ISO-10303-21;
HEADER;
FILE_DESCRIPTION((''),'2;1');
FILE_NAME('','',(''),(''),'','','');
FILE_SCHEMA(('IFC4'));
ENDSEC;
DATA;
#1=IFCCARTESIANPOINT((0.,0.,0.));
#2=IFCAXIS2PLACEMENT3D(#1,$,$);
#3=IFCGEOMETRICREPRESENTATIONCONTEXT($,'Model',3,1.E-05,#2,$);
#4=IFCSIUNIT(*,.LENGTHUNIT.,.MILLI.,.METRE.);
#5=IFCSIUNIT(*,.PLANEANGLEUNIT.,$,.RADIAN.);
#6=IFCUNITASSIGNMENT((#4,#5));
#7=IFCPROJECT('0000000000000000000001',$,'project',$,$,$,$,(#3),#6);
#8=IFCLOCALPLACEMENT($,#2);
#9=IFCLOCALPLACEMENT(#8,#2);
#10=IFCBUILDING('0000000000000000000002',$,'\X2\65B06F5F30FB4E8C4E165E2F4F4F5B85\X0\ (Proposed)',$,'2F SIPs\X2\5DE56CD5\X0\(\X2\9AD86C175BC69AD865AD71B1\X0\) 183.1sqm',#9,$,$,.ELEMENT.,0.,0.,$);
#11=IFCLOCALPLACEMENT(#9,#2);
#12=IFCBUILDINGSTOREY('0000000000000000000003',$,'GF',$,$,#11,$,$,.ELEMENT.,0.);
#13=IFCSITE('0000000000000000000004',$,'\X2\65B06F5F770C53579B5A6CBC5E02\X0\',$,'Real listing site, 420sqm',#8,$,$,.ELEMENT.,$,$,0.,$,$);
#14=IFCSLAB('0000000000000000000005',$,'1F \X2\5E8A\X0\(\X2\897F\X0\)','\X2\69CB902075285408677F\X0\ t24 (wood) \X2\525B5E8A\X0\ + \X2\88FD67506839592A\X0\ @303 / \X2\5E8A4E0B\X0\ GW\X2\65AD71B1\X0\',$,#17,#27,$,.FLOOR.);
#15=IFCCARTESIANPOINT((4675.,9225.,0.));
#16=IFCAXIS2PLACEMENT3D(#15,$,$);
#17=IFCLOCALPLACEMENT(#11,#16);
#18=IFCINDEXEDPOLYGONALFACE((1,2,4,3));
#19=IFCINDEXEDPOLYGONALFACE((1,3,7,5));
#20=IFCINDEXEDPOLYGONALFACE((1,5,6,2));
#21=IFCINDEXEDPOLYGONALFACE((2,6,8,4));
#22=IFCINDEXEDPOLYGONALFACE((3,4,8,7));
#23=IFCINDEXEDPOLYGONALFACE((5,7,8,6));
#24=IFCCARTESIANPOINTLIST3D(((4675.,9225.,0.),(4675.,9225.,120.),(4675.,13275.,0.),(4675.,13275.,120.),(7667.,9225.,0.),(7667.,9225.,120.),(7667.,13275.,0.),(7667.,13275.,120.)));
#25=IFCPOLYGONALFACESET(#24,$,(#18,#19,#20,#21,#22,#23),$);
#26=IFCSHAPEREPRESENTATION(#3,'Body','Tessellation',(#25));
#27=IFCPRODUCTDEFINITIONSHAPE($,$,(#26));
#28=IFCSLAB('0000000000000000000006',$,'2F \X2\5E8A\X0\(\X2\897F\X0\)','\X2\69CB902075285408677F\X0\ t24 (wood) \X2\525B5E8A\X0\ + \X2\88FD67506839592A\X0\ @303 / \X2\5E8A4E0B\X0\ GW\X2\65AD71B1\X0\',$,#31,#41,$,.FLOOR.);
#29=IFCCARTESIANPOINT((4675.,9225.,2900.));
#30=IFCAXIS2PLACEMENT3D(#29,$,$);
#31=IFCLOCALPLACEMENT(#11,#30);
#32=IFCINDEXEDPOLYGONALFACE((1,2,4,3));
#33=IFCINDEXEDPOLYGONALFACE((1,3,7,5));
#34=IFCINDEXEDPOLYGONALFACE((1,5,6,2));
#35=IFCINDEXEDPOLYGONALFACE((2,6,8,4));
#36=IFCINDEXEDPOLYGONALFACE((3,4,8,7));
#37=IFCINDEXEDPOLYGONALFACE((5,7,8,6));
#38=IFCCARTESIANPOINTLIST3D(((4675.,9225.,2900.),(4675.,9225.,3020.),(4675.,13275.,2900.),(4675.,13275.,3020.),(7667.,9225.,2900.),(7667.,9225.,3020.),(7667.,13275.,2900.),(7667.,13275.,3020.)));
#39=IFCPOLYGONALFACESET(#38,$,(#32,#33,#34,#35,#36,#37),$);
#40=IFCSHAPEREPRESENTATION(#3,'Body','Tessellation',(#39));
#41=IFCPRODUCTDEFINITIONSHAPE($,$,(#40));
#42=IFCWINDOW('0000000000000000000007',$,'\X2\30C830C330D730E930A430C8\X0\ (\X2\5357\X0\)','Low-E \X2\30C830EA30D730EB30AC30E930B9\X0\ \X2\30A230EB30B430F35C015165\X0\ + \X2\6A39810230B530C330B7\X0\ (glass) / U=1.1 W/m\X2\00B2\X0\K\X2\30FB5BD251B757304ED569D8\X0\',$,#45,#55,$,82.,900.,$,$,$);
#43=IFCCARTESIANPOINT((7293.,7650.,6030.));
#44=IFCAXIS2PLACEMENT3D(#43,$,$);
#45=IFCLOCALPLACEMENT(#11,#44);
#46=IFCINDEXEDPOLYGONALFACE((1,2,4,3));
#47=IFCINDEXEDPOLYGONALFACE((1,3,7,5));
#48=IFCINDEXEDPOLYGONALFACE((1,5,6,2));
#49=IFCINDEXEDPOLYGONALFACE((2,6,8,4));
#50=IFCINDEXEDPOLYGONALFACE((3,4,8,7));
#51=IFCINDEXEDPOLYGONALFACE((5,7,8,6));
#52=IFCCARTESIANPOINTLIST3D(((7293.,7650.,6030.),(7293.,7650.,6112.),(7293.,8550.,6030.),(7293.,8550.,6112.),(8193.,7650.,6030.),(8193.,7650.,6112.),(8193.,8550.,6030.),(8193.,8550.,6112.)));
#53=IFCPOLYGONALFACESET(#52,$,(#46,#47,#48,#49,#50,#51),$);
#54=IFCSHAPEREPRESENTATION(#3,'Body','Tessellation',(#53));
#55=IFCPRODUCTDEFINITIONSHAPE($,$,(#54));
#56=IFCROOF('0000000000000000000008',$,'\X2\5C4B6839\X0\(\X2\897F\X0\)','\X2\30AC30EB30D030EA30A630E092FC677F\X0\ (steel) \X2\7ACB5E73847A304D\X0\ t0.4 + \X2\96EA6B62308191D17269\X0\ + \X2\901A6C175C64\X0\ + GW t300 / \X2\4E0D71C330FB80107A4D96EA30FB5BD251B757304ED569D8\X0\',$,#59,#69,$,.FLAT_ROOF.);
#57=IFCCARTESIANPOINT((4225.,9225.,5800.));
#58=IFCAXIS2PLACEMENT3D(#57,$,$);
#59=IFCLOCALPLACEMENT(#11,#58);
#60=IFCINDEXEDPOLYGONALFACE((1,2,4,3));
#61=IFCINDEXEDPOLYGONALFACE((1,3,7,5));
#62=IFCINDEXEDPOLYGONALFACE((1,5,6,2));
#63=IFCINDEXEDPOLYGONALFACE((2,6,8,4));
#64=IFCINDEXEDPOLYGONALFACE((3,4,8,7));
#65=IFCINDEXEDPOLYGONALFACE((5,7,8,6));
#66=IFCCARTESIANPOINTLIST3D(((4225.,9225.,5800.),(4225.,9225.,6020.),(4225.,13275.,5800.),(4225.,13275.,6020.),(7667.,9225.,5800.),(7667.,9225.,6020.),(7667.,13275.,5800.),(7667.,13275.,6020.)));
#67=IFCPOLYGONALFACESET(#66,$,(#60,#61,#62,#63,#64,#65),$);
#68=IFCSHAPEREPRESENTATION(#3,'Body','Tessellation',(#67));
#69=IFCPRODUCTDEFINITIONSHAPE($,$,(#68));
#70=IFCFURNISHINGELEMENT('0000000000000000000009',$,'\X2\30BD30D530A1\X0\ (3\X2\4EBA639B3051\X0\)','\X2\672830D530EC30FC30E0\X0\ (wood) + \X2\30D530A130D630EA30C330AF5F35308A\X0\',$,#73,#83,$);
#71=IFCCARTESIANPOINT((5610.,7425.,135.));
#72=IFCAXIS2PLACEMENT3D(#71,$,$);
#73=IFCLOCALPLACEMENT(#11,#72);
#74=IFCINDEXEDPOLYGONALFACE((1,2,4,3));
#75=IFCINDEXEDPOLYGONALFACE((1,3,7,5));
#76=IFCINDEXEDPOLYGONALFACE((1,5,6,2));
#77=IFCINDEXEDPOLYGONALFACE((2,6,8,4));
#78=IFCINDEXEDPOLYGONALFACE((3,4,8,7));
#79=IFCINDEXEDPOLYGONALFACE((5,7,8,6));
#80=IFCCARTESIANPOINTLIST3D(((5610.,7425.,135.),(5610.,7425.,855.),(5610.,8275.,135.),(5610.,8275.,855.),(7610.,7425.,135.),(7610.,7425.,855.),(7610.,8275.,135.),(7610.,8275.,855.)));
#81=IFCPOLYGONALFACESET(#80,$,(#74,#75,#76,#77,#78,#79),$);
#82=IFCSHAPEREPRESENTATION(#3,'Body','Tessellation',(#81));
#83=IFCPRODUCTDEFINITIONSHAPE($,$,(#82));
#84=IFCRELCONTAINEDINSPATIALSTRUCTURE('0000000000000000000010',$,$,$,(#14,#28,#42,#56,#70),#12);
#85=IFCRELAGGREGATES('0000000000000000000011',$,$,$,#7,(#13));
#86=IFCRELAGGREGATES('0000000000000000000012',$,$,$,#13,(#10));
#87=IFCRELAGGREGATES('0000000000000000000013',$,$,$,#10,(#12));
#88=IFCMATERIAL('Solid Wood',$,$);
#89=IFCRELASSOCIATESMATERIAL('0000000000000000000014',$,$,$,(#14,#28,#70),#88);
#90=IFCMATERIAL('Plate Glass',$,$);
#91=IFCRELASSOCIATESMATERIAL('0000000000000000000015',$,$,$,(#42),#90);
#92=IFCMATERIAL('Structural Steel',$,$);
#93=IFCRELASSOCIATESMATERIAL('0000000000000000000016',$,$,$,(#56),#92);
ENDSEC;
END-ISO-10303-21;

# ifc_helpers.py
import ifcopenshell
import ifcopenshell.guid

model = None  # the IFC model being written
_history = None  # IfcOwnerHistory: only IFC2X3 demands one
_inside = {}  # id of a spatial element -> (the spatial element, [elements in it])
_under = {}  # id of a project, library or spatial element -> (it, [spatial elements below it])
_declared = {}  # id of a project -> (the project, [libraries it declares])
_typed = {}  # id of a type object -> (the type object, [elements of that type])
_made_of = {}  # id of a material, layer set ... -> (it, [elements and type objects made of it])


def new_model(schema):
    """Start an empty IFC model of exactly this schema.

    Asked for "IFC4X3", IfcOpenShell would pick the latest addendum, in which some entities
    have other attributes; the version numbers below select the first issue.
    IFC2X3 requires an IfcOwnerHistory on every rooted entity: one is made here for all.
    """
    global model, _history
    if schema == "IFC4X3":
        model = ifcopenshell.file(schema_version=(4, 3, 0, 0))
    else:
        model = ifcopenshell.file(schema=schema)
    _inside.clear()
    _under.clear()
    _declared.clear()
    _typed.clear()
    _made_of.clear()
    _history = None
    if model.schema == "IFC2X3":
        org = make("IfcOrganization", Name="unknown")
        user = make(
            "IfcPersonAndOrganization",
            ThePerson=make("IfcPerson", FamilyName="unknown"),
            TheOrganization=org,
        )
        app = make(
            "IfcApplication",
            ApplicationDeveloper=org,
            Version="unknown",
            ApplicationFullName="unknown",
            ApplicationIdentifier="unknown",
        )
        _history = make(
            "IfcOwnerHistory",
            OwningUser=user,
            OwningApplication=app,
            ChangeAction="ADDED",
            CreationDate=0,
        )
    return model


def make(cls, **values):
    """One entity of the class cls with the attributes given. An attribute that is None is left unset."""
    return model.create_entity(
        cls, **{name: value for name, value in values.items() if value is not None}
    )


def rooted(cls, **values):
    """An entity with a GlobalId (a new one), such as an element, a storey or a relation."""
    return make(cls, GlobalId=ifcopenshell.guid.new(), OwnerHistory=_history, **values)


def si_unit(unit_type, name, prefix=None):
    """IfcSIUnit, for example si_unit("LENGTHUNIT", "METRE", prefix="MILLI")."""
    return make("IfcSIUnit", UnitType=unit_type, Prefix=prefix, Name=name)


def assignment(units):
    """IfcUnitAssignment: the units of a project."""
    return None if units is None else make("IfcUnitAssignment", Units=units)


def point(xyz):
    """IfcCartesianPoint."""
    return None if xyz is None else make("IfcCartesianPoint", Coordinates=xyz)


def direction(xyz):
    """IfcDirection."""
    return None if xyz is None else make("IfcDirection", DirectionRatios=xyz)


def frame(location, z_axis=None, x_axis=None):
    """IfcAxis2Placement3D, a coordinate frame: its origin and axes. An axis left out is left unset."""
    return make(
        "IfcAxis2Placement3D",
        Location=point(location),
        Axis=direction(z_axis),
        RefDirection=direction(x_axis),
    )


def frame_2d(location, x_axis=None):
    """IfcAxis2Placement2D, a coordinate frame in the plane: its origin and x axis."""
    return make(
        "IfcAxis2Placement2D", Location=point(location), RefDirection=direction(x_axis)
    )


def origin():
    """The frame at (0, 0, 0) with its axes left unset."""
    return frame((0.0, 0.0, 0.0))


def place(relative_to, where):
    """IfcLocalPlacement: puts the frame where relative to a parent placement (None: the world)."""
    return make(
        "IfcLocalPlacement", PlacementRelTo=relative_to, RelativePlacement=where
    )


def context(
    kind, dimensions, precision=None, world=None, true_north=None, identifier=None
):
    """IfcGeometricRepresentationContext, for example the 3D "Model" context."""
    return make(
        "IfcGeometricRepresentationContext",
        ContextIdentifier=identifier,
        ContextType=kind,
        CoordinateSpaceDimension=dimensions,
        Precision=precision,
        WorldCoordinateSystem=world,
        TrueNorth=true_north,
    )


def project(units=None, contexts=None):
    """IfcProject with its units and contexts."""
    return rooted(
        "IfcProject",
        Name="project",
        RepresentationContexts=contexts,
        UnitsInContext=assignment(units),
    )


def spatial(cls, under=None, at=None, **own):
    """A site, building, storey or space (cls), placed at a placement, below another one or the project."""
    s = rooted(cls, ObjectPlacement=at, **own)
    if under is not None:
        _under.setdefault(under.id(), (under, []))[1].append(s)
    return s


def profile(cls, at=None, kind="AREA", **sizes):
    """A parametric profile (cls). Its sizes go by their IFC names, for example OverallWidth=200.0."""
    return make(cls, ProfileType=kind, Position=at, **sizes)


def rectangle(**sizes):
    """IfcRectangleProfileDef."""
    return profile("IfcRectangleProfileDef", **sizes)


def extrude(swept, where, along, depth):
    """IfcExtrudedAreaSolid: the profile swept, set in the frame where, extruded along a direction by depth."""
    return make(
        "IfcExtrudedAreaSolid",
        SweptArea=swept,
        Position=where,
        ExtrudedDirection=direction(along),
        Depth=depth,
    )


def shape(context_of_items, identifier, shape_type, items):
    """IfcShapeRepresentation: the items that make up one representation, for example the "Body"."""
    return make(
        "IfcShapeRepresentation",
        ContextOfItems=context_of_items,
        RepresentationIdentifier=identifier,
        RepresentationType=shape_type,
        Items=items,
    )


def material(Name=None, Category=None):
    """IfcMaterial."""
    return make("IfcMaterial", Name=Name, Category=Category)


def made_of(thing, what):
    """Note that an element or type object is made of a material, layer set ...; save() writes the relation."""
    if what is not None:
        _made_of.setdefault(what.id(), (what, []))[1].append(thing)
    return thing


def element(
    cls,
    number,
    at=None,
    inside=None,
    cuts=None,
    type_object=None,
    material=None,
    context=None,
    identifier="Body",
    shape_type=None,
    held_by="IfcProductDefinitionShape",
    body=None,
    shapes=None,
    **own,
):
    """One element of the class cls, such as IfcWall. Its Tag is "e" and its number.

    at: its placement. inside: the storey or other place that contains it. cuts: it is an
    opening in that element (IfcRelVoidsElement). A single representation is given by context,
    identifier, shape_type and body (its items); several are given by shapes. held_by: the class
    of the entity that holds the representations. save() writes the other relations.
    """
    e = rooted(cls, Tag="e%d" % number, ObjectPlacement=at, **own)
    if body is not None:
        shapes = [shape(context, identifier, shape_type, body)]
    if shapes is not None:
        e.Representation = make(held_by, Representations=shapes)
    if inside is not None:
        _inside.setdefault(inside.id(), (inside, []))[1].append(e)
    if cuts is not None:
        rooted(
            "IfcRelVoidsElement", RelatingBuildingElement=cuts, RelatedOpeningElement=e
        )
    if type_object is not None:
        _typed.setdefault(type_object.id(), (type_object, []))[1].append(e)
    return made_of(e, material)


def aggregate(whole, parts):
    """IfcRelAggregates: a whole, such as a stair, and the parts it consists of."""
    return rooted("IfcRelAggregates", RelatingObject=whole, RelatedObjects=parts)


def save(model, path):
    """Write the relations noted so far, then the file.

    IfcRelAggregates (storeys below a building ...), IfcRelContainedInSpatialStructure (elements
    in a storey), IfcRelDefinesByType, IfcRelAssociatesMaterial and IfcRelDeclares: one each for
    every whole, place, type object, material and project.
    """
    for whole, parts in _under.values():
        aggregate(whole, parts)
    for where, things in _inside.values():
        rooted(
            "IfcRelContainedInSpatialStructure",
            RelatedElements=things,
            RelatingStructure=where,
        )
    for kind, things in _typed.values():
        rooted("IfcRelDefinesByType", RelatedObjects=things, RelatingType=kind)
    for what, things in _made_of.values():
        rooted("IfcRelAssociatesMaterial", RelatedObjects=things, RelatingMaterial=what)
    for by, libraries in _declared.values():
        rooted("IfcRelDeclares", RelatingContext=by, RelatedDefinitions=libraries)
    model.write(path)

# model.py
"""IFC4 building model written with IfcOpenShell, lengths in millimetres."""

from ifc_helpers import new_model, si_unit, frame, frame_2d, origin, place, context, project, spatial, rectangle, extrude, material, element, save


model = new_model("IFC4")

# Units and contexts
model_context = context("Model", 3, precision=1e-05, world=origin())
ifc_project = project(units=[si_unit("LENGTHUNIT", "METRE", prefix="MILLI"), si_unit("PLANEANGLEUNIT", "RADIAN")], contexts=[model_context])

# Site, building, storey
site_placement = place(None, origin())
site = spatial("IfcSite", under=ifc_project, at=site_placement, Name="新潟県南魚沼市", ObjectType="Real listing site, 420sqm", CompositionType="ELEMENT", RefElevation=0.0)
building_placement = place(site_placement, origin())
building = spatial("IfcBuilding", under=site, at=building_placement, Name="新潟・二世帯住宅 (Proposed)", ObjectType="2F SIPs工法(高気密高断熱) 183.1sqm", CompositionType="ELEMENT", ElevationOfRefHeight=0.0, ElevationOfTerrain=0.0)
storey_placement = place(building_placement, origin())
storey = spatial("IfcBuildingStorey", under=building, at=storey_placement, Name="GF", CompositionType="ELEMENT", Elevation=0.0)

# Shared definitions
ifc_material_1 = material(Name="Solid Wood")

# Slabs
slab_1_placement = place(storey_placement, frame((4675.0, 9225.0, 0.0)))
element("IfcSlab", 1, at=slab_1_placement, inside=storey, material=ifc_material_1, Name="1F 床(西)", Description="構造用合板 t24 (wood) 剛床 + 製材根太 @303 / 床下 GW断熱", PredefinedType="FLOOR", context=model_context, shape_type="SweptSolid", body=[
    extrude(rectangle(XDim=2992.0, YDim=4050.0, at=frame_2d((1496.0, 2025.0))), frame((4675.0, 9225.0, 0.0)), (0.0, 0.0, 1.0), 120.0),
])
slab_2_placement = place(storey_placement, frame((4675.0, 9225.0, 2900.0)))
element("IfcSlab", 2, at=slab_2_placement, inside=storey, material=ifc_material_1, Name="2F 床(西)", Description="構造用合板 t24 (wood) 剛床 + 製材根太 @303 / 床下 GW断熱", PredefinedType="FLOOR", context=model_context, shape_type="SweptSolid", body=[
    extrude(rectangle(XDim=2992.0, YDim=4050.0, at=frame_2d((1496.0, 2025.0))), frame((4675.0, 9225.0, 2900.0)), (0.0, 0.0, 1.0), 120.0),
])

# Window
ifc_material_2 = material(Name="Plate Glass")
window_placement = place(storey_placement, frame((7293.0, 7650.0, 6030.0)))
element("IfcWindow", 3, at=window_placement, inside=storey, material=ifc_material_2, Name="トップライト (南)", Description="Low-E トリプルガラス アルゴン封入 + 樹脂サッシ (glass) / U=1.1 W/m²K・寒冷地仕様", OverallHeight=82.0, OverallWidth=900.0, context=model_context, shape_type="SweptSolid", body=[
    extrude(rectangle(XDim=900.0, YDim=900.0, at=frame_2d((450.0, 450.0))), frame((7293.0, 7650.0, 6030.0)), (0.0, 0.0, 1.0), 82.0),
])

# Roof
ifc_material_3 = material(Name="Structural Steel")
for number, where, name in (
    (4, (4225.0, 9225.0, 5800.0), "屋根(西)"),
):
    element("IfcRoof", number, at=place(storey_placement, frame(where)), inside=storey, material=ifc_material_3, Name=name, Description="ガルバリウム鋼板 (steel) 立平葺き t0.4 + 雪止め金物 + 通気層 + GW t300 / 不燃・耐積雪・寒冷地仕様", PredefinedType="FLAT_ROOF", context=model_context, shape_type="SweptSolid", body=[
        extrude(rectangle(XDim=3442.0, YDim=4050.0, at=frame_2d((1721.0, 2025.0))), frame((4225.0, 9225.0, 5800.0)), (0.0, 0.0, 1.0), 220.0),
    ])

# Furnishing element
furnishing_placement = place(storey_placement, frame((5610.0, 7425.0, 135.0)))
element("IfcFurnishingElement", 5, at=furnishing_placement, inside=storey, material=ifc_material_1, Name="ソファ (3人掛け)", Description="木フレーム (wood) + ファブリック張り", context=model_context, shape_type="SweptSolid", body=[
    extrude(rectangle(XDim=2000.0, YDim=850.0, at=frame_2d((1000.0, 425.0))), frame((5610.0, 7425.0, 135.0)), (0.0, 0.0, 1.0), 720.0),
])

save(model, "model.ifc")
